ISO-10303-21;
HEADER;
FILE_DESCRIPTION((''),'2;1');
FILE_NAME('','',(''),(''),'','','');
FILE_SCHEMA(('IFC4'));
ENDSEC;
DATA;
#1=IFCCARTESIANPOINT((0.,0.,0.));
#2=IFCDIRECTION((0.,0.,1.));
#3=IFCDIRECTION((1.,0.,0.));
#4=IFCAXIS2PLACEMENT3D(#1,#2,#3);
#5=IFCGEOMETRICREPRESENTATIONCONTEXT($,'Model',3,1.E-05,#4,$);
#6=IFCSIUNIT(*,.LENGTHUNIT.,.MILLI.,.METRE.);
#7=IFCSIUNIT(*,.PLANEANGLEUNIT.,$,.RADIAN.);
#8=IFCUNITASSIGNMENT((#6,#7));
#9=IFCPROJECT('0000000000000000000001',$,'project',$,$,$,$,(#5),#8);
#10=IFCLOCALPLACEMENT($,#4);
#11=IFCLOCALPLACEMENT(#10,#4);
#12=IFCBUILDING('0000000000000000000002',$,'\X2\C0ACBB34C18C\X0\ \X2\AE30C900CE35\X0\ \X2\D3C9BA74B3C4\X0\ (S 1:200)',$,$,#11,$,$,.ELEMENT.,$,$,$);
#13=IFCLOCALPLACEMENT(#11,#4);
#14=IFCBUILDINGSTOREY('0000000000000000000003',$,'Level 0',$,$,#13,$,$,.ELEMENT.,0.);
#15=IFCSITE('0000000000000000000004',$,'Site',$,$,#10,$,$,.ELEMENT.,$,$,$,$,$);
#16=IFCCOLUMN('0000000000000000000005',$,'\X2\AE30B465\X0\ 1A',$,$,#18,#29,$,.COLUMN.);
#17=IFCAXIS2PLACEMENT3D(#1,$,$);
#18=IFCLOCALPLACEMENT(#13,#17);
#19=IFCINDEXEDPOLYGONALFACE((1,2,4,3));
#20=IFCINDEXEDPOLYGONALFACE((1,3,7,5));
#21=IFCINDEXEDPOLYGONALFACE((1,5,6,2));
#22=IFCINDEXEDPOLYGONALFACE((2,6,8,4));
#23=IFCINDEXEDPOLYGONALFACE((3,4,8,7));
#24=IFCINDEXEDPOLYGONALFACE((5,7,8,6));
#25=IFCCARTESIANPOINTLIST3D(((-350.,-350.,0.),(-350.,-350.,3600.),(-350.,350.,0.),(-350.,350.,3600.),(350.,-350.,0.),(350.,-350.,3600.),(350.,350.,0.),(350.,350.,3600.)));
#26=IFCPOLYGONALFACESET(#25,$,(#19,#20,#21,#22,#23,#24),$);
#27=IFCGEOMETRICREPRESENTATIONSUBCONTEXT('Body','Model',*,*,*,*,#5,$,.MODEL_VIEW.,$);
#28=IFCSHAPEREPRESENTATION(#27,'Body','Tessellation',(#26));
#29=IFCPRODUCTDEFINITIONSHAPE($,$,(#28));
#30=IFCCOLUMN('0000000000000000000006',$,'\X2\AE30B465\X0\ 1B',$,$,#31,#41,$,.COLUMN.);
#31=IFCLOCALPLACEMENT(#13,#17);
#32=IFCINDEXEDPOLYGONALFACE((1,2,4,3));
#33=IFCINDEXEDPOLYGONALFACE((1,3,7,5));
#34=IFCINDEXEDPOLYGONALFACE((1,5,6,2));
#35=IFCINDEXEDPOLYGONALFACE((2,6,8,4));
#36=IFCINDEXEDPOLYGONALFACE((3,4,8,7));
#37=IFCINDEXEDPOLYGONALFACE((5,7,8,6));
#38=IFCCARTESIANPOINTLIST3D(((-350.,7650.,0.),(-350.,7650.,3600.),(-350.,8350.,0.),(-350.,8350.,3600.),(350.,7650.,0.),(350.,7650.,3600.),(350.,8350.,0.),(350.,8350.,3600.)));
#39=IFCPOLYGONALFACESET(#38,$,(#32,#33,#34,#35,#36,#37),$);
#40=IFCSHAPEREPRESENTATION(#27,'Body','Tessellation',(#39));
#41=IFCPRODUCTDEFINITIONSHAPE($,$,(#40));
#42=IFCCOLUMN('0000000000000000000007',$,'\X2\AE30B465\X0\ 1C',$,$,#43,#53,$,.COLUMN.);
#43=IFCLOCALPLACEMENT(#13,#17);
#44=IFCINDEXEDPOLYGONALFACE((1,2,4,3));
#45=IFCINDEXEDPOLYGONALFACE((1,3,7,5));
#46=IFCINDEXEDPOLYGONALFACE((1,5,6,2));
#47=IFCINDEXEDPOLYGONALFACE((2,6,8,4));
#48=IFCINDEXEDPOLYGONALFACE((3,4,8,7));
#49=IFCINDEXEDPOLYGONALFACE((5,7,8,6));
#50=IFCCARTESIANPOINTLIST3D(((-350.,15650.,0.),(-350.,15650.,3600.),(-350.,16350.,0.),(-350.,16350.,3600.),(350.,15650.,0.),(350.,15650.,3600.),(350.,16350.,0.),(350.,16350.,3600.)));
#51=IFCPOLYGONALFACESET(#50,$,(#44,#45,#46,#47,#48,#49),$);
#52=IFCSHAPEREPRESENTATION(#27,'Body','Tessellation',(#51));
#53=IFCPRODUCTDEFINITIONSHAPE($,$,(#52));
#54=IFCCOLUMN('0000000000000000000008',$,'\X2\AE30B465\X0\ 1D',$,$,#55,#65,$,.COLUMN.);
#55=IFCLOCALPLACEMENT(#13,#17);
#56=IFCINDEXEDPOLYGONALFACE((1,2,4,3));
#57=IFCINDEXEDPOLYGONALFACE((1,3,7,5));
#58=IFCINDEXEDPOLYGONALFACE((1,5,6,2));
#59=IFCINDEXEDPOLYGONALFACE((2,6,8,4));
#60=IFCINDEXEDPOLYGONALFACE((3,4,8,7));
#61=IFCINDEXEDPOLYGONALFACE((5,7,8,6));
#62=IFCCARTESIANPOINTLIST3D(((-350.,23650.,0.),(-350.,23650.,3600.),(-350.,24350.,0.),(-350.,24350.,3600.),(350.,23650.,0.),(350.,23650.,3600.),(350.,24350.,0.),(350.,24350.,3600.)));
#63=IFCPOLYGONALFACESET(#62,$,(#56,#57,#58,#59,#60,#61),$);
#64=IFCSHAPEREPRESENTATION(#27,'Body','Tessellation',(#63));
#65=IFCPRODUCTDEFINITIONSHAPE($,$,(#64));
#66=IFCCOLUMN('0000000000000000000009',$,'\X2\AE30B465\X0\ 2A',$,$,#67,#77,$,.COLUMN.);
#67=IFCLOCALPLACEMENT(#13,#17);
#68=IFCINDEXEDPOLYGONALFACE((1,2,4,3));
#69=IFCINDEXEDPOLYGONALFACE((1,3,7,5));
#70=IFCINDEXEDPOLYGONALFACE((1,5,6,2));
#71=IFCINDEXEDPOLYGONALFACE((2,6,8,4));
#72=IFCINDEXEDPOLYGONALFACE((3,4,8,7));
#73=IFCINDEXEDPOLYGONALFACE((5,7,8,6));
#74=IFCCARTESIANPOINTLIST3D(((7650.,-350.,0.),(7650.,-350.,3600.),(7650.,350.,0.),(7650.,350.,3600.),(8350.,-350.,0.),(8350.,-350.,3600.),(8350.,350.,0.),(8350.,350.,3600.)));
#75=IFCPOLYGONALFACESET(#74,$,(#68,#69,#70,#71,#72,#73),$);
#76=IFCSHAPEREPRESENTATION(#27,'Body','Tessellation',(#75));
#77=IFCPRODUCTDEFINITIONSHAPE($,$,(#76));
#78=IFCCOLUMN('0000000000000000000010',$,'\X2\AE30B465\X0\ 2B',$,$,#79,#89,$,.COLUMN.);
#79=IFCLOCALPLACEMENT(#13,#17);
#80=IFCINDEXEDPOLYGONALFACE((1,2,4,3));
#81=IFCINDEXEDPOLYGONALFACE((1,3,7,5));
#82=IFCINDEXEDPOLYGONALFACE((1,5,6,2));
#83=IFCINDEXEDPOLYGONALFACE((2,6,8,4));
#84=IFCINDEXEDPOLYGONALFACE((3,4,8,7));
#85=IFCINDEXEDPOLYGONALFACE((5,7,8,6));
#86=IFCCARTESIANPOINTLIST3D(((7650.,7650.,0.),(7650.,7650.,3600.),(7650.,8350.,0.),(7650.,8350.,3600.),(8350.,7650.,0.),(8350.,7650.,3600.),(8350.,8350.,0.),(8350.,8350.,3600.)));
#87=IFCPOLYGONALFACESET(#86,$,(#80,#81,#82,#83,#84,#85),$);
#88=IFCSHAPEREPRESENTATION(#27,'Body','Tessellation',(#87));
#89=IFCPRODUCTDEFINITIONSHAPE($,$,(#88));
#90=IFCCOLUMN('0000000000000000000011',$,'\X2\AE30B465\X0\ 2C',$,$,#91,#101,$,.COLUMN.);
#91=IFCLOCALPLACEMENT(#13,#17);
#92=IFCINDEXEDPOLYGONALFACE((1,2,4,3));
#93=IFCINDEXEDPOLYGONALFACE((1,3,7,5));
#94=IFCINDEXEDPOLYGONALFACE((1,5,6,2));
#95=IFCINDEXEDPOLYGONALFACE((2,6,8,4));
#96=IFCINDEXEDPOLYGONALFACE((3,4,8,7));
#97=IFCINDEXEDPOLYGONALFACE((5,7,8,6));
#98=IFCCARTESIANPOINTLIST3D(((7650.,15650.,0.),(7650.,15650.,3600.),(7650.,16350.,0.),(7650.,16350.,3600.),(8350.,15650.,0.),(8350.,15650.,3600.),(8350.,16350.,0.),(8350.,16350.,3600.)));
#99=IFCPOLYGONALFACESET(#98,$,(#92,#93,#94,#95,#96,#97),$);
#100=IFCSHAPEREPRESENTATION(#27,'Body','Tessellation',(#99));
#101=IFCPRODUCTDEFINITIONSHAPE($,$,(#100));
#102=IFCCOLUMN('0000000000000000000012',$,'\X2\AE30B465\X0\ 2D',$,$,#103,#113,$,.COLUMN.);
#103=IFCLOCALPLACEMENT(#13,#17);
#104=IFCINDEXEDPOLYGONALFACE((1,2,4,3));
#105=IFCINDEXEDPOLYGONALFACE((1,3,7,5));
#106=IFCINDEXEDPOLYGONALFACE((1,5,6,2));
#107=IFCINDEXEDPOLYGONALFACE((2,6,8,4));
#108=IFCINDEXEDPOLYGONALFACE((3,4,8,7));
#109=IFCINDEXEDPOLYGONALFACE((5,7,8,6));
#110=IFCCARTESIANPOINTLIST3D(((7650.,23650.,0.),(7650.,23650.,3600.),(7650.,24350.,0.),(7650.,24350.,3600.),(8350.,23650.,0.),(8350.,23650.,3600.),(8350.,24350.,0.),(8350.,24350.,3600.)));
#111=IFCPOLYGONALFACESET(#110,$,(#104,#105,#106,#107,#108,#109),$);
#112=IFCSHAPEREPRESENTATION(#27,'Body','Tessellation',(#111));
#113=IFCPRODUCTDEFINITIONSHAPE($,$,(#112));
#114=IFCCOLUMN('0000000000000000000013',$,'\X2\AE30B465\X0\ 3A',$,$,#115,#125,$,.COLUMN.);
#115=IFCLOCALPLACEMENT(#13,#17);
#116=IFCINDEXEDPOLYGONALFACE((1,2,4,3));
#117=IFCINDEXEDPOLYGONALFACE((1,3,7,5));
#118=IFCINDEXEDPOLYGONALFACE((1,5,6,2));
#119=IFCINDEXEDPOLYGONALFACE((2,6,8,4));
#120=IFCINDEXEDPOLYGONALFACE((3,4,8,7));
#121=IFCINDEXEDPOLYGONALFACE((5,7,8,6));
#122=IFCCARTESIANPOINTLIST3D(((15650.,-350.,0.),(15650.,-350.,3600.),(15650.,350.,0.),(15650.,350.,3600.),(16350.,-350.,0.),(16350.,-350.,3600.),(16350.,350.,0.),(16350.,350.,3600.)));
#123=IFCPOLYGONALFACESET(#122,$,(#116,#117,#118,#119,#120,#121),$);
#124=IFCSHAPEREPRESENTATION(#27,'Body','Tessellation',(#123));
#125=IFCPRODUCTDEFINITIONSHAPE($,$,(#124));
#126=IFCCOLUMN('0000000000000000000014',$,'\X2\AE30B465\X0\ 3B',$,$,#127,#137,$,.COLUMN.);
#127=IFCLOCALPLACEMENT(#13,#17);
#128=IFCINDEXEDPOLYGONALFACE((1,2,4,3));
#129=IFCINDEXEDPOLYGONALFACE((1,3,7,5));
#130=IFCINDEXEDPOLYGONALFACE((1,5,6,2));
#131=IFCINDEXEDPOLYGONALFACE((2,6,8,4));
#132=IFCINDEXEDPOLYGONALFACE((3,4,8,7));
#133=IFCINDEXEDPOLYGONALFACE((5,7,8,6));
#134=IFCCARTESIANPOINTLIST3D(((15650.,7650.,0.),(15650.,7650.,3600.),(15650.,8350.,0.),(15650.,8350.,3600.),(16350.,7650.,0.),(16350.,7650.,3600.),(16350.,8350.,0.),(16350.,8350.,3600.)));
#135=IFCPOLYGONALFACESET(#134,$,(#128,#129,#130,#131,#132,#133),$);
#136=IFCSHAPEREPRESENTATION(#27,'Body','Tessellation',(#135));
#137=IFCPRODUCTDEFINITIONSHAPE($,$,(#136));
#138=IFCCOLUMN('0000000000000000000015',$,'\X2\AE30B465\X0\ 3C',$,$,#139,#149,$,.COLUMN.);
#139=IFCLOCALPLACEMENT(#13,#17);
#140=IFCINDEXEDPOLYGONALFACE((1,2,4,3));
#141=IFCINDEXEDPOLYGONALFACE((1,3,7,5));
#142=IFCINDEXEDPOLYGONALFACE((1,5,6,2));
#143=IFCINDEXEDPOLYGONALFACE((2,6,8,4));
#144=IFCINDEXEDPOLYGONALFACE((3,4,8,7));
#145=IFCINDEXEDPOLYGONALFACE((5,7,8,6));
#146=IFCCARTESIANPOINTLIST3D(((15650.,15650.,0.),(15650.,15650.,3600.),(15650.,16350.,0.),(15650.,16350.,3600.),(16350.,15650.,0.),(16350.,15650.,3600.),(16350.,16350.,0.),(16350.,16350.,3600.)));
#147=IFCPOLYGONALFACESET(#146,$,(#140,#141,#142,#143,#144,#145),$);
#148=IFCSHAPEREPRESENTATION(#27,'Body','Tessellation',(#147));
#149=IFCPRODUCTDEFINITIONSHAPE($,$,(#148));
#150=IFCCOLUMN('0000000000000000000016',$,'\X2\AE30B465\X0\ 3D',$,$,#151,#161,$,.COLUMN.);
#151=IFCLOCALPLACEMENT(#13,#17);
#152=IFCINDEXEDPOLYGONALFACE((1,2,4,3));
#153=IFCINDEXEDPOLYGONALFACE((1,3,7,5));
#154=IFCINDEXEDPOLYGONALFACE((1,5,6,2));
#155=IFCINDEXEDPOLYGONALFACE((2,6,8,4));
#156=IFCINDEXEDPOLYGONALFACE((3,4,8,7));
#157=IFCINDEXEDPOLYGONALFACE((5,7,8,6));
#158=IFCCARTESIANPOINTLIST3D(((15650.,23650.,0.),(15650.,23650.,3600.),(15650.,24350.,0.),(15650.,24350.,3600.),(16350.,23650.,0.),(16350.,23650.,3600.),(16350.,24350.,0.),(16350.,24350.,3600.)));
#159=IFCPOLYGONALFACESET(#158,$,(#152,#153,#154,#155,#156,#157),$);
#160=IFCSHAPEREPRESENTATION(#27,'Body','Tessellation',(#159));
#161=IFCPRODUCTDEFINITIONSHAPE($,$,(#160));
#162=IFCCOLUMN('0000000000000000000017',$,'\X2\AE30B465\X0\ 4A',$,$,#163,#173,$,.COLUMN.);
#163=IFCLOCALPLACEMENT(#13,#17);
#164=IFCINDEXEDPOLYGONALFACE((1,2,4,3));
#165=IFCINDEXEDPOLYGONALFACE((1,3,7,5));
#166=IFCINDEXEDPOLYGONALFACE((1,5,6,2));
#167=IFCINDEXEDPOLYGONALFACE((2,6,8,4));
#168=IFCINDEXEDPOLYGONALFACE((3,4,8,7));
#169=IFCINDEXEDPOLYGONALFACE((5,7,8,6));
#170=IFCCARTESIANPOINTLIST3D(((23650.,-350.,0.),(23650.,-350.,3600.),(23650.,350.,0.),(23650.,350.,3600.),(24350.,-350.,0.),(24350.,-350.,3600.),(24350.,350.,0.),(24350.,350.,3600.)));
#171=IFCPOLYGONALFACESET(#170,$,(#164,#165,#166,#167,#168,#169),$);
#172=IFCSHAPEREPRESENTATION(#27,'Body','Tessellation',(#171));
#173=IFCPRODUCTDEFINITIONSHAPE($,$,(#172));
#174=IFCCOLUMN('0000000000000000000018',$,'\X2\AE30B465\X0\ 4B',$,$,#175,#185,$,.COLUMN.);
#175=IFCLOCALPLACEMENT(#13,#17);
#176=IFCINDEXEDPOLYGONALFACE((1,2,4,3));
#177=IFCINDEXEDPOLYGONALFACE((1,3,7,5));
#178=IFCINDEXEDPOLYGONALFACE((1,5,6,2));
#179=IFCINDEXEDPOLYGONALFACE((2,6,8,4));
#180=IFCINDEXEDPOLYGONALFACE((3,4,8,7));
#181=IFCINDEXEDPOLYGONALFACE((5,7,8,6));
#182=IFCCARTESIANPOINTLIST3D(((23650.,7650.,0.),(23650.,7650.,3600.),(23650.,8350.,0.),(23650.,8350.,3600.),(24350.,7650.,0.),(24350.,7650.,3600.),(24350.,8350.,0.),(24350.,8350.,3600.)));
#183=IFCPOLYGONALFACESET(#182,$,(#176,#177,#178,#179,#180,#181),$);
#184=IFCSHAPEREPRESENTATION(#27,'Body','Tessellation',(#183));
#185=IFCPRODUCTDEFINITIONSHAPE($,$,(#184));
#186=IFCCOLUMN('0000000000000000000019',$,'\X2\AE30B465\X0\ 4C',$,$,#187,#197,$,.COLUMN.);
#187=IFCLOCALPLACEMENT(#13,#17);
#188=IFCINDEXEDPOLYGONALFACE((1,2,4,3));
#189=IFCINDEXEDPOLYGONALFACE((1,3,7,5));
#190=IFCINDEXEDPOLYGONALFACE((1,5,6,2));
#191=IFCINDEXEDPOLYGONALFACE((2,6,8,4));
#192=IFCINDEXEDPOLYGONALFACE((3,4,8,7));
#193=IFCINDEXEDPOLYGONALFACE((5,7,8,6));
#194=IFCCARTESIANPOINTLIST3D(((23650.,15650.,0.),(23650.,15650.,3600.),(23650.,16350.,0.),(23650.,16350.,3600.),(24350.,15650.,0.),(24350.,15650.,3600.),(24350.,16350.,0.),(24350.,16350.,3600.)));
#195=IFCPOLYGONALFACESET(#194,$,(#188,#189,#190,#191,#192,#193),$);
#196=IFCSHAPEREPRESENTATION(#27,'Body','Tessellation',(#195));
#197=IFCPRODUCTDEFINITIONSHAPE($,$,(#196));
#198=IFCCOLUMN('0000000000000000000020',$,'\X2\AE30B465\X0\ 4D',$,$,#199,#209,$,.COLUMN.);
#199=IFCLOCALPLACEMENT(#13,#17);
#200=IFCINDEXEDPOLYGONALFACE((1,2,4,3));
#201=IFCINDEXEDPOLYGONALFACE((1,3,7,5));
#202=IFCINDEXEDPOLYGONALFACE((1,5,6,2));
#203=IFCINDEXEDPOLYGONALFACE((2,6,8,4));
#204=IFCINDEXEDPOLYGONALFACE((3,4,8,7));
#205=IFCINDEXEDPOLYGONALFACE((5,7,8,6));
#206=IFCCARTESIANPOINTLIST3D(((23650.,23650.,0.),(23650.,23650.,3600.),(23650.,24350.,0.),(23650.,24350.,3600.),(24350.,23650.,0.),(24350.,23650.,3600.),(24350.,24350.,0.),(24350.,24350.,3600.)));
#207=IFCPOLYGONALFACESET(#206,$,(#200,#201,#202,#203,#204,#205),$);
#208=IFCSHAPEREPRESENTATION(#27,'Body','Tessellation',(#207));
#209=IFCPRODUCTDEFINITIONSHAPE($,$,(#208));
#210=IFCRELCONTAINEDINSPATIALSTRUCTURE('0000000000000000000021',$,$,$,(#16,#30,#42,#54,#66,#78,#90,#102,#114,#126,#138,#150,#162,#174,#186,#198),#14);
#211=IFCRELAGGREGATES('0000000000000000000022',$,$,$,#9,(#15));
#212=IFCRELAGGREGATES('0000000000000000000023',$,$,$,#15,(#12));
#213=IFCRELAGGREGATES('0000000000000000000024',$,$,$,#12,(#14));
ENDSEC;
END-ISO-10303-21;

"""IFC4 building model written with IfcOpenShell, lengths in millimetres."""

from ifc_helpers import new_model, si_unit, frame, origin_with_axes, origin_2d, place, context, subcontext, project, spatial, rectangle, extrude, element, save


model = new_model("IFC4")

# Units and contexts
model_context = context("Model", 3, precision=1e-05, world=origin_with_axes())
body_context = subcontext(model_context, "Body", "Model", "MODEL_VIEW")
ifc_project = project(units=[si_unit("LENGTHUNIT", "METRE", prefix="MILLI"), si_unit("PLANEANGLEUNIT", "RADIAN")], contexts=[model_context])

# Site, building, storey
site_placement = place(None, origin_with_axes())
site = spatial("IfcSite", under=ifc_project, at=site_placement, Name="Site", CompositionType="ELEMENT")
building_placement = place(site_placement, origin_with_axes())
building = spatial("IfcBuilding", under=site, at=building_placement, Name="사무소 기준층 평면도 (S 1:200)", CompositionType="ELEMENT")
storey_placement = place(building_placement, origin_with_axes())
storey = spatial("IfcBuildingStorey", under=building, at=storey_placement, Name="Level 0", CompositionType="ELEMENT", Elevation=0.0)

# Columns
column_1_placement = place(storey_placement, origin_with_axes())
element("IfcColumn", 1, at=column_1_placement, inside=storey, Name="기둥 1A", PredefinedType="COLUMN", context=body_context, shape_type="SweptSolid", body=[
    extrude(rectangle(XDim=700.0, YDim=700.0, at=origin_2d()), origin_with_axes(), (0.0, 0.0, 1.0), 3600.0),
])
column_2_placement = place(storey_placement, origin_with_axes())
element("IfcColumn", 2, at=column_2_placement, inside=storey, Name="기둥 1B", PredefinedType="COLUMN", context=body_context, shape_type="SweptSolid", body=[
    extrude(rectangle(XDim=700.0, YDim=700.0, at=origin_2d()), frame((0.0, 8000.0, 0.0), z_axis=(0.0, 0.0, 1.0), x_axis=(1.0, 0.0, 0.0)), (0.0, 0.0, 1.0), 3600.0),
])
column_3_placement = place(storey_placement, origin_with_axes())
element("IfcColumn", 3, at=column_3_placement, inside=storey, Name="기둥 1C", PredefinedType="COLUMN", context=body_context, shape_type="SweptSolid", body=[
    extrude(rectangle(XDim=700.0, YDim=700.0, at=origin_2d()), frame((0.0, 16000.0, 0.0), z_axis=(0.0, 0.0, 1.0), x_axis=(1.0, 0.0, 0.0)), (0.0, 0.0, 1.0), 3600.0),
])
column_4_placement = place(storey_placement, origin_with_axes())
element("IfcColumn", 4, at=column_4_placement, inside=storey, Name="기둥 1D", PredefinedType="COLUMN", context=body_context, shape_type="SweptSolid", body=[
    extrude(rectangle(XDim=700.0, YDim=700.0, at=origin_2d()), frame((0.0, 24000.0, 0.0), z_axis=(0.0, 0.0, 1.0), x_axis=(1.0, 0.0, 0.0)), (0.0, 0.0, 1.0), 3600.0),
])
column_5_placement = place(storey_placement, origin_with_axes())
element("IfcColumn", 5, at=column_5_placement, inside=storey, Name="기둥 2A", PredefinedType="COLUMN", context=body_context, shape_type="SweptSolid", body=[
    extrude(rectangle(XDim=700.0, YDim=700.0, at=origin_2d()), frame((8000.0, 0.0, 0.0), z_axis=(0.0, 0.0, 1.0), x_axis=(1.0, 0.0, 0.0)), (0.0, 0.0, 1.0), 3600.0),
])
column_6_placement = place(storey_placement, origin_with_axes())
element("IfcColumn", 6, at=column_6_placement, inside=storey, Name="기둥 2B", PredefinedType="COLUMN", context=body_context, shape_type="SweptSolid", body=[
    extrude(rectangle(XDim=700.0, YDim=700.0, at=origin_2d()), frame((8000.0, 8000.0, 0.0), z_axis=(0.0, 0.0, 1.0), x_axis=(1.0, 0.0, 0.0)), (0.0, 0.0, 1.0), 3600.0),
])
column_7_placement = place(storey_placement, origin_with_axes())
element("IfcColumn", 7, at=column_7_placement, inside=storey, Name="기둥 2C", PredefinedType="COLUMN", context=body_context, shape_type="SweptSolid", body=[
    extrude(rectangle(XDim=700.0, YDim=700.0, at=origin_2d()), frame((8000.0, 16000.0, 0.0), z_axis=(0.0, 0.0, 1.0), x_axis=(1.0, 0.0, 0.0)), (0.0, 0.0, 1.0), 3600.0),
])
column_8_placement = place(storey_placement, origin_with_axes())
element("IfcColumn", 8, at=column_8_placement, inside=storey, Name="기둥 2D", PredefinedType="COLUMN", context=body_context, shape_type="SweptSolid", body=[
    extrude(rectangle(XDim=700.0, YDim=700.0, at=origin_2d()), frame((8000.0, 24000.0, 0.0), z_axis=(0.0, 0.0, 1.0), x_axis=(1.0, 0.0, 0.0)), (0.0, 0.0, 1.0), 3600.0),
])
column_9_placement = place(storey_placement, origin_with_axes())
element("IfcColumn", 9, at=column_9_placement, inside=storey, Name="기둥 3A", PredefinedType="COLUMN", context=body_context, shape_type="SweptSolid", body=[
    extrude(rectangle(XDim=700.0, YDim=700.0, at=origin_2d()), frame((16000.0, 0.0, 0.0), z_axis=(0.0, 0.0, 1.0), x_axis=(1.0, 0.0, 0.0)), (0.0, 0.0, 1.0), 3600.0),
])
column_10_placement = place(storey_placement, origin_with_axes())
element("IfcColumn", 10, at=column_10_placement, inside=storey, Name="기둥 3B", PredefinedType="COLUMN", context=body_context, shape_type="SweptSolid", body=[
    extrude(rectangle(XDim=700.0, YDim=700.0, at=origin_2d()), frame((16000.0, 8000.0, 0.0), z_axis=(0.0, 0.0, 1.0), x_axis=(1.0, 0.0, 0.0)), (0.0, 0.0, 1.0), 3600.0),
])
column_11_placement = place(storey_placement, origin_with_axes())
element("IfcColumn", 11, at=column_11_placement, inside=storey, Name="기둥 3C", PredefinedType="COLUMN", context=body_context, shape_type="SweptSolid", body=[
    extrude(rectangle(XDim=700.0, YDim=700.0, at=origin_2d()), frame((16000.0, 16000.0, 0.0), z_axis=(0.0, 0.0, 1.0), x_axis=(1.0, 0.0, 0.0)), (0.0, 0.0, 1.0), 3600.0),
])
column_12_placement = place(storey_placement, origin_with_axes())
element("IfcColumn", 12, at=column_12_placement, inside=storey, Name="기둥 3D", PredefinedType="COLUMN", context=body_context, shape_type="SweptSolid", body=[
    extrude(rectangle(XDim=700.0, YDim=700.0, at=origin_2d()), frame((16000.0, 24000.0, 0.0), z_axis=(0.0, 0.0, 1.0), x_axis=(1.0, 0.0, 0.0)), (0.0, 0.0, 1.0), 3600.0),
])
column_13_placement = place(storey_placement, origin_with_axes())
element("IfcColumn", 13, at=column_13_placement, inside=storey, Name="기둥 4A", PredefinedType="COLUMN", context=body_context, shape_type="SweptSolid", body=[
    extrude(rectangle(XDim=700.0, YDim=700.0, at=origin_2d()), frame((24000.0, 0.0, 0.0), z_axis=(0.0, 0.0, 1.0), x_axis=(1.0, 0.0, 0.0)), (0.0, 0.0, 1.0), 3600.0),
])
column_14_placement = place(storey_placement, origin_with_axes())
element("IfcColumn", 14, at=column_14_placement, inside=storey, Name="기둥 4B", PredefinedType="COLUMN", context=body_context, shape_type="SweptSolid", body=[
    extrude(rectangle(XDim=700.0, YDim=700.0, at=origin_2d()), frame((24000.0, 8000.0, 0.0), z_axis=(0.0, 0.0, 1.0), x_axis=(1.0, 0.0, 0.0)), (0.0, 0.0, 1.0), 3600.0),
])
column_15_placement = place(storey_placement, origin_with_axes())
element("IfcColumn", 15, at=column_15_placement, inside=storey, Name="기둥 4C", PredefinedType="COLUMN", context=body_context, shape_type="SweptSolid", body=[
    extrude(rectangle(XDim=700.0, YDim=700.0, at=origin_2d()), frame((24000.0, 16000.0, 0.0), z_axis=(0.0, 0.0, 1.0), x_axis=(1.0, 0.0, 0.0)), (0.0, 0.0, 1.0), 3600.0),
])
column_16_placement = place(storey_placement, origin_with_axes())
element("IfcColumn", 16, at=column_16_placement, inside=storey, Name="기둥 4D", PredefinedType="COLUMN", context=body_context, shape_type="SweptSolid", body=[
    extrude(rectangle(XDim=700.0, YDim=700.0, at=origin_2d()), frame((24000.0, 24000.0, 0.0), z_axis=(0.0, 0.0, 1.0), x_axis=(1.0, 0.0, 0.0)), (0.0, 0.0, 1.0), 3600.0),
])

save(model, "model.ifc")
